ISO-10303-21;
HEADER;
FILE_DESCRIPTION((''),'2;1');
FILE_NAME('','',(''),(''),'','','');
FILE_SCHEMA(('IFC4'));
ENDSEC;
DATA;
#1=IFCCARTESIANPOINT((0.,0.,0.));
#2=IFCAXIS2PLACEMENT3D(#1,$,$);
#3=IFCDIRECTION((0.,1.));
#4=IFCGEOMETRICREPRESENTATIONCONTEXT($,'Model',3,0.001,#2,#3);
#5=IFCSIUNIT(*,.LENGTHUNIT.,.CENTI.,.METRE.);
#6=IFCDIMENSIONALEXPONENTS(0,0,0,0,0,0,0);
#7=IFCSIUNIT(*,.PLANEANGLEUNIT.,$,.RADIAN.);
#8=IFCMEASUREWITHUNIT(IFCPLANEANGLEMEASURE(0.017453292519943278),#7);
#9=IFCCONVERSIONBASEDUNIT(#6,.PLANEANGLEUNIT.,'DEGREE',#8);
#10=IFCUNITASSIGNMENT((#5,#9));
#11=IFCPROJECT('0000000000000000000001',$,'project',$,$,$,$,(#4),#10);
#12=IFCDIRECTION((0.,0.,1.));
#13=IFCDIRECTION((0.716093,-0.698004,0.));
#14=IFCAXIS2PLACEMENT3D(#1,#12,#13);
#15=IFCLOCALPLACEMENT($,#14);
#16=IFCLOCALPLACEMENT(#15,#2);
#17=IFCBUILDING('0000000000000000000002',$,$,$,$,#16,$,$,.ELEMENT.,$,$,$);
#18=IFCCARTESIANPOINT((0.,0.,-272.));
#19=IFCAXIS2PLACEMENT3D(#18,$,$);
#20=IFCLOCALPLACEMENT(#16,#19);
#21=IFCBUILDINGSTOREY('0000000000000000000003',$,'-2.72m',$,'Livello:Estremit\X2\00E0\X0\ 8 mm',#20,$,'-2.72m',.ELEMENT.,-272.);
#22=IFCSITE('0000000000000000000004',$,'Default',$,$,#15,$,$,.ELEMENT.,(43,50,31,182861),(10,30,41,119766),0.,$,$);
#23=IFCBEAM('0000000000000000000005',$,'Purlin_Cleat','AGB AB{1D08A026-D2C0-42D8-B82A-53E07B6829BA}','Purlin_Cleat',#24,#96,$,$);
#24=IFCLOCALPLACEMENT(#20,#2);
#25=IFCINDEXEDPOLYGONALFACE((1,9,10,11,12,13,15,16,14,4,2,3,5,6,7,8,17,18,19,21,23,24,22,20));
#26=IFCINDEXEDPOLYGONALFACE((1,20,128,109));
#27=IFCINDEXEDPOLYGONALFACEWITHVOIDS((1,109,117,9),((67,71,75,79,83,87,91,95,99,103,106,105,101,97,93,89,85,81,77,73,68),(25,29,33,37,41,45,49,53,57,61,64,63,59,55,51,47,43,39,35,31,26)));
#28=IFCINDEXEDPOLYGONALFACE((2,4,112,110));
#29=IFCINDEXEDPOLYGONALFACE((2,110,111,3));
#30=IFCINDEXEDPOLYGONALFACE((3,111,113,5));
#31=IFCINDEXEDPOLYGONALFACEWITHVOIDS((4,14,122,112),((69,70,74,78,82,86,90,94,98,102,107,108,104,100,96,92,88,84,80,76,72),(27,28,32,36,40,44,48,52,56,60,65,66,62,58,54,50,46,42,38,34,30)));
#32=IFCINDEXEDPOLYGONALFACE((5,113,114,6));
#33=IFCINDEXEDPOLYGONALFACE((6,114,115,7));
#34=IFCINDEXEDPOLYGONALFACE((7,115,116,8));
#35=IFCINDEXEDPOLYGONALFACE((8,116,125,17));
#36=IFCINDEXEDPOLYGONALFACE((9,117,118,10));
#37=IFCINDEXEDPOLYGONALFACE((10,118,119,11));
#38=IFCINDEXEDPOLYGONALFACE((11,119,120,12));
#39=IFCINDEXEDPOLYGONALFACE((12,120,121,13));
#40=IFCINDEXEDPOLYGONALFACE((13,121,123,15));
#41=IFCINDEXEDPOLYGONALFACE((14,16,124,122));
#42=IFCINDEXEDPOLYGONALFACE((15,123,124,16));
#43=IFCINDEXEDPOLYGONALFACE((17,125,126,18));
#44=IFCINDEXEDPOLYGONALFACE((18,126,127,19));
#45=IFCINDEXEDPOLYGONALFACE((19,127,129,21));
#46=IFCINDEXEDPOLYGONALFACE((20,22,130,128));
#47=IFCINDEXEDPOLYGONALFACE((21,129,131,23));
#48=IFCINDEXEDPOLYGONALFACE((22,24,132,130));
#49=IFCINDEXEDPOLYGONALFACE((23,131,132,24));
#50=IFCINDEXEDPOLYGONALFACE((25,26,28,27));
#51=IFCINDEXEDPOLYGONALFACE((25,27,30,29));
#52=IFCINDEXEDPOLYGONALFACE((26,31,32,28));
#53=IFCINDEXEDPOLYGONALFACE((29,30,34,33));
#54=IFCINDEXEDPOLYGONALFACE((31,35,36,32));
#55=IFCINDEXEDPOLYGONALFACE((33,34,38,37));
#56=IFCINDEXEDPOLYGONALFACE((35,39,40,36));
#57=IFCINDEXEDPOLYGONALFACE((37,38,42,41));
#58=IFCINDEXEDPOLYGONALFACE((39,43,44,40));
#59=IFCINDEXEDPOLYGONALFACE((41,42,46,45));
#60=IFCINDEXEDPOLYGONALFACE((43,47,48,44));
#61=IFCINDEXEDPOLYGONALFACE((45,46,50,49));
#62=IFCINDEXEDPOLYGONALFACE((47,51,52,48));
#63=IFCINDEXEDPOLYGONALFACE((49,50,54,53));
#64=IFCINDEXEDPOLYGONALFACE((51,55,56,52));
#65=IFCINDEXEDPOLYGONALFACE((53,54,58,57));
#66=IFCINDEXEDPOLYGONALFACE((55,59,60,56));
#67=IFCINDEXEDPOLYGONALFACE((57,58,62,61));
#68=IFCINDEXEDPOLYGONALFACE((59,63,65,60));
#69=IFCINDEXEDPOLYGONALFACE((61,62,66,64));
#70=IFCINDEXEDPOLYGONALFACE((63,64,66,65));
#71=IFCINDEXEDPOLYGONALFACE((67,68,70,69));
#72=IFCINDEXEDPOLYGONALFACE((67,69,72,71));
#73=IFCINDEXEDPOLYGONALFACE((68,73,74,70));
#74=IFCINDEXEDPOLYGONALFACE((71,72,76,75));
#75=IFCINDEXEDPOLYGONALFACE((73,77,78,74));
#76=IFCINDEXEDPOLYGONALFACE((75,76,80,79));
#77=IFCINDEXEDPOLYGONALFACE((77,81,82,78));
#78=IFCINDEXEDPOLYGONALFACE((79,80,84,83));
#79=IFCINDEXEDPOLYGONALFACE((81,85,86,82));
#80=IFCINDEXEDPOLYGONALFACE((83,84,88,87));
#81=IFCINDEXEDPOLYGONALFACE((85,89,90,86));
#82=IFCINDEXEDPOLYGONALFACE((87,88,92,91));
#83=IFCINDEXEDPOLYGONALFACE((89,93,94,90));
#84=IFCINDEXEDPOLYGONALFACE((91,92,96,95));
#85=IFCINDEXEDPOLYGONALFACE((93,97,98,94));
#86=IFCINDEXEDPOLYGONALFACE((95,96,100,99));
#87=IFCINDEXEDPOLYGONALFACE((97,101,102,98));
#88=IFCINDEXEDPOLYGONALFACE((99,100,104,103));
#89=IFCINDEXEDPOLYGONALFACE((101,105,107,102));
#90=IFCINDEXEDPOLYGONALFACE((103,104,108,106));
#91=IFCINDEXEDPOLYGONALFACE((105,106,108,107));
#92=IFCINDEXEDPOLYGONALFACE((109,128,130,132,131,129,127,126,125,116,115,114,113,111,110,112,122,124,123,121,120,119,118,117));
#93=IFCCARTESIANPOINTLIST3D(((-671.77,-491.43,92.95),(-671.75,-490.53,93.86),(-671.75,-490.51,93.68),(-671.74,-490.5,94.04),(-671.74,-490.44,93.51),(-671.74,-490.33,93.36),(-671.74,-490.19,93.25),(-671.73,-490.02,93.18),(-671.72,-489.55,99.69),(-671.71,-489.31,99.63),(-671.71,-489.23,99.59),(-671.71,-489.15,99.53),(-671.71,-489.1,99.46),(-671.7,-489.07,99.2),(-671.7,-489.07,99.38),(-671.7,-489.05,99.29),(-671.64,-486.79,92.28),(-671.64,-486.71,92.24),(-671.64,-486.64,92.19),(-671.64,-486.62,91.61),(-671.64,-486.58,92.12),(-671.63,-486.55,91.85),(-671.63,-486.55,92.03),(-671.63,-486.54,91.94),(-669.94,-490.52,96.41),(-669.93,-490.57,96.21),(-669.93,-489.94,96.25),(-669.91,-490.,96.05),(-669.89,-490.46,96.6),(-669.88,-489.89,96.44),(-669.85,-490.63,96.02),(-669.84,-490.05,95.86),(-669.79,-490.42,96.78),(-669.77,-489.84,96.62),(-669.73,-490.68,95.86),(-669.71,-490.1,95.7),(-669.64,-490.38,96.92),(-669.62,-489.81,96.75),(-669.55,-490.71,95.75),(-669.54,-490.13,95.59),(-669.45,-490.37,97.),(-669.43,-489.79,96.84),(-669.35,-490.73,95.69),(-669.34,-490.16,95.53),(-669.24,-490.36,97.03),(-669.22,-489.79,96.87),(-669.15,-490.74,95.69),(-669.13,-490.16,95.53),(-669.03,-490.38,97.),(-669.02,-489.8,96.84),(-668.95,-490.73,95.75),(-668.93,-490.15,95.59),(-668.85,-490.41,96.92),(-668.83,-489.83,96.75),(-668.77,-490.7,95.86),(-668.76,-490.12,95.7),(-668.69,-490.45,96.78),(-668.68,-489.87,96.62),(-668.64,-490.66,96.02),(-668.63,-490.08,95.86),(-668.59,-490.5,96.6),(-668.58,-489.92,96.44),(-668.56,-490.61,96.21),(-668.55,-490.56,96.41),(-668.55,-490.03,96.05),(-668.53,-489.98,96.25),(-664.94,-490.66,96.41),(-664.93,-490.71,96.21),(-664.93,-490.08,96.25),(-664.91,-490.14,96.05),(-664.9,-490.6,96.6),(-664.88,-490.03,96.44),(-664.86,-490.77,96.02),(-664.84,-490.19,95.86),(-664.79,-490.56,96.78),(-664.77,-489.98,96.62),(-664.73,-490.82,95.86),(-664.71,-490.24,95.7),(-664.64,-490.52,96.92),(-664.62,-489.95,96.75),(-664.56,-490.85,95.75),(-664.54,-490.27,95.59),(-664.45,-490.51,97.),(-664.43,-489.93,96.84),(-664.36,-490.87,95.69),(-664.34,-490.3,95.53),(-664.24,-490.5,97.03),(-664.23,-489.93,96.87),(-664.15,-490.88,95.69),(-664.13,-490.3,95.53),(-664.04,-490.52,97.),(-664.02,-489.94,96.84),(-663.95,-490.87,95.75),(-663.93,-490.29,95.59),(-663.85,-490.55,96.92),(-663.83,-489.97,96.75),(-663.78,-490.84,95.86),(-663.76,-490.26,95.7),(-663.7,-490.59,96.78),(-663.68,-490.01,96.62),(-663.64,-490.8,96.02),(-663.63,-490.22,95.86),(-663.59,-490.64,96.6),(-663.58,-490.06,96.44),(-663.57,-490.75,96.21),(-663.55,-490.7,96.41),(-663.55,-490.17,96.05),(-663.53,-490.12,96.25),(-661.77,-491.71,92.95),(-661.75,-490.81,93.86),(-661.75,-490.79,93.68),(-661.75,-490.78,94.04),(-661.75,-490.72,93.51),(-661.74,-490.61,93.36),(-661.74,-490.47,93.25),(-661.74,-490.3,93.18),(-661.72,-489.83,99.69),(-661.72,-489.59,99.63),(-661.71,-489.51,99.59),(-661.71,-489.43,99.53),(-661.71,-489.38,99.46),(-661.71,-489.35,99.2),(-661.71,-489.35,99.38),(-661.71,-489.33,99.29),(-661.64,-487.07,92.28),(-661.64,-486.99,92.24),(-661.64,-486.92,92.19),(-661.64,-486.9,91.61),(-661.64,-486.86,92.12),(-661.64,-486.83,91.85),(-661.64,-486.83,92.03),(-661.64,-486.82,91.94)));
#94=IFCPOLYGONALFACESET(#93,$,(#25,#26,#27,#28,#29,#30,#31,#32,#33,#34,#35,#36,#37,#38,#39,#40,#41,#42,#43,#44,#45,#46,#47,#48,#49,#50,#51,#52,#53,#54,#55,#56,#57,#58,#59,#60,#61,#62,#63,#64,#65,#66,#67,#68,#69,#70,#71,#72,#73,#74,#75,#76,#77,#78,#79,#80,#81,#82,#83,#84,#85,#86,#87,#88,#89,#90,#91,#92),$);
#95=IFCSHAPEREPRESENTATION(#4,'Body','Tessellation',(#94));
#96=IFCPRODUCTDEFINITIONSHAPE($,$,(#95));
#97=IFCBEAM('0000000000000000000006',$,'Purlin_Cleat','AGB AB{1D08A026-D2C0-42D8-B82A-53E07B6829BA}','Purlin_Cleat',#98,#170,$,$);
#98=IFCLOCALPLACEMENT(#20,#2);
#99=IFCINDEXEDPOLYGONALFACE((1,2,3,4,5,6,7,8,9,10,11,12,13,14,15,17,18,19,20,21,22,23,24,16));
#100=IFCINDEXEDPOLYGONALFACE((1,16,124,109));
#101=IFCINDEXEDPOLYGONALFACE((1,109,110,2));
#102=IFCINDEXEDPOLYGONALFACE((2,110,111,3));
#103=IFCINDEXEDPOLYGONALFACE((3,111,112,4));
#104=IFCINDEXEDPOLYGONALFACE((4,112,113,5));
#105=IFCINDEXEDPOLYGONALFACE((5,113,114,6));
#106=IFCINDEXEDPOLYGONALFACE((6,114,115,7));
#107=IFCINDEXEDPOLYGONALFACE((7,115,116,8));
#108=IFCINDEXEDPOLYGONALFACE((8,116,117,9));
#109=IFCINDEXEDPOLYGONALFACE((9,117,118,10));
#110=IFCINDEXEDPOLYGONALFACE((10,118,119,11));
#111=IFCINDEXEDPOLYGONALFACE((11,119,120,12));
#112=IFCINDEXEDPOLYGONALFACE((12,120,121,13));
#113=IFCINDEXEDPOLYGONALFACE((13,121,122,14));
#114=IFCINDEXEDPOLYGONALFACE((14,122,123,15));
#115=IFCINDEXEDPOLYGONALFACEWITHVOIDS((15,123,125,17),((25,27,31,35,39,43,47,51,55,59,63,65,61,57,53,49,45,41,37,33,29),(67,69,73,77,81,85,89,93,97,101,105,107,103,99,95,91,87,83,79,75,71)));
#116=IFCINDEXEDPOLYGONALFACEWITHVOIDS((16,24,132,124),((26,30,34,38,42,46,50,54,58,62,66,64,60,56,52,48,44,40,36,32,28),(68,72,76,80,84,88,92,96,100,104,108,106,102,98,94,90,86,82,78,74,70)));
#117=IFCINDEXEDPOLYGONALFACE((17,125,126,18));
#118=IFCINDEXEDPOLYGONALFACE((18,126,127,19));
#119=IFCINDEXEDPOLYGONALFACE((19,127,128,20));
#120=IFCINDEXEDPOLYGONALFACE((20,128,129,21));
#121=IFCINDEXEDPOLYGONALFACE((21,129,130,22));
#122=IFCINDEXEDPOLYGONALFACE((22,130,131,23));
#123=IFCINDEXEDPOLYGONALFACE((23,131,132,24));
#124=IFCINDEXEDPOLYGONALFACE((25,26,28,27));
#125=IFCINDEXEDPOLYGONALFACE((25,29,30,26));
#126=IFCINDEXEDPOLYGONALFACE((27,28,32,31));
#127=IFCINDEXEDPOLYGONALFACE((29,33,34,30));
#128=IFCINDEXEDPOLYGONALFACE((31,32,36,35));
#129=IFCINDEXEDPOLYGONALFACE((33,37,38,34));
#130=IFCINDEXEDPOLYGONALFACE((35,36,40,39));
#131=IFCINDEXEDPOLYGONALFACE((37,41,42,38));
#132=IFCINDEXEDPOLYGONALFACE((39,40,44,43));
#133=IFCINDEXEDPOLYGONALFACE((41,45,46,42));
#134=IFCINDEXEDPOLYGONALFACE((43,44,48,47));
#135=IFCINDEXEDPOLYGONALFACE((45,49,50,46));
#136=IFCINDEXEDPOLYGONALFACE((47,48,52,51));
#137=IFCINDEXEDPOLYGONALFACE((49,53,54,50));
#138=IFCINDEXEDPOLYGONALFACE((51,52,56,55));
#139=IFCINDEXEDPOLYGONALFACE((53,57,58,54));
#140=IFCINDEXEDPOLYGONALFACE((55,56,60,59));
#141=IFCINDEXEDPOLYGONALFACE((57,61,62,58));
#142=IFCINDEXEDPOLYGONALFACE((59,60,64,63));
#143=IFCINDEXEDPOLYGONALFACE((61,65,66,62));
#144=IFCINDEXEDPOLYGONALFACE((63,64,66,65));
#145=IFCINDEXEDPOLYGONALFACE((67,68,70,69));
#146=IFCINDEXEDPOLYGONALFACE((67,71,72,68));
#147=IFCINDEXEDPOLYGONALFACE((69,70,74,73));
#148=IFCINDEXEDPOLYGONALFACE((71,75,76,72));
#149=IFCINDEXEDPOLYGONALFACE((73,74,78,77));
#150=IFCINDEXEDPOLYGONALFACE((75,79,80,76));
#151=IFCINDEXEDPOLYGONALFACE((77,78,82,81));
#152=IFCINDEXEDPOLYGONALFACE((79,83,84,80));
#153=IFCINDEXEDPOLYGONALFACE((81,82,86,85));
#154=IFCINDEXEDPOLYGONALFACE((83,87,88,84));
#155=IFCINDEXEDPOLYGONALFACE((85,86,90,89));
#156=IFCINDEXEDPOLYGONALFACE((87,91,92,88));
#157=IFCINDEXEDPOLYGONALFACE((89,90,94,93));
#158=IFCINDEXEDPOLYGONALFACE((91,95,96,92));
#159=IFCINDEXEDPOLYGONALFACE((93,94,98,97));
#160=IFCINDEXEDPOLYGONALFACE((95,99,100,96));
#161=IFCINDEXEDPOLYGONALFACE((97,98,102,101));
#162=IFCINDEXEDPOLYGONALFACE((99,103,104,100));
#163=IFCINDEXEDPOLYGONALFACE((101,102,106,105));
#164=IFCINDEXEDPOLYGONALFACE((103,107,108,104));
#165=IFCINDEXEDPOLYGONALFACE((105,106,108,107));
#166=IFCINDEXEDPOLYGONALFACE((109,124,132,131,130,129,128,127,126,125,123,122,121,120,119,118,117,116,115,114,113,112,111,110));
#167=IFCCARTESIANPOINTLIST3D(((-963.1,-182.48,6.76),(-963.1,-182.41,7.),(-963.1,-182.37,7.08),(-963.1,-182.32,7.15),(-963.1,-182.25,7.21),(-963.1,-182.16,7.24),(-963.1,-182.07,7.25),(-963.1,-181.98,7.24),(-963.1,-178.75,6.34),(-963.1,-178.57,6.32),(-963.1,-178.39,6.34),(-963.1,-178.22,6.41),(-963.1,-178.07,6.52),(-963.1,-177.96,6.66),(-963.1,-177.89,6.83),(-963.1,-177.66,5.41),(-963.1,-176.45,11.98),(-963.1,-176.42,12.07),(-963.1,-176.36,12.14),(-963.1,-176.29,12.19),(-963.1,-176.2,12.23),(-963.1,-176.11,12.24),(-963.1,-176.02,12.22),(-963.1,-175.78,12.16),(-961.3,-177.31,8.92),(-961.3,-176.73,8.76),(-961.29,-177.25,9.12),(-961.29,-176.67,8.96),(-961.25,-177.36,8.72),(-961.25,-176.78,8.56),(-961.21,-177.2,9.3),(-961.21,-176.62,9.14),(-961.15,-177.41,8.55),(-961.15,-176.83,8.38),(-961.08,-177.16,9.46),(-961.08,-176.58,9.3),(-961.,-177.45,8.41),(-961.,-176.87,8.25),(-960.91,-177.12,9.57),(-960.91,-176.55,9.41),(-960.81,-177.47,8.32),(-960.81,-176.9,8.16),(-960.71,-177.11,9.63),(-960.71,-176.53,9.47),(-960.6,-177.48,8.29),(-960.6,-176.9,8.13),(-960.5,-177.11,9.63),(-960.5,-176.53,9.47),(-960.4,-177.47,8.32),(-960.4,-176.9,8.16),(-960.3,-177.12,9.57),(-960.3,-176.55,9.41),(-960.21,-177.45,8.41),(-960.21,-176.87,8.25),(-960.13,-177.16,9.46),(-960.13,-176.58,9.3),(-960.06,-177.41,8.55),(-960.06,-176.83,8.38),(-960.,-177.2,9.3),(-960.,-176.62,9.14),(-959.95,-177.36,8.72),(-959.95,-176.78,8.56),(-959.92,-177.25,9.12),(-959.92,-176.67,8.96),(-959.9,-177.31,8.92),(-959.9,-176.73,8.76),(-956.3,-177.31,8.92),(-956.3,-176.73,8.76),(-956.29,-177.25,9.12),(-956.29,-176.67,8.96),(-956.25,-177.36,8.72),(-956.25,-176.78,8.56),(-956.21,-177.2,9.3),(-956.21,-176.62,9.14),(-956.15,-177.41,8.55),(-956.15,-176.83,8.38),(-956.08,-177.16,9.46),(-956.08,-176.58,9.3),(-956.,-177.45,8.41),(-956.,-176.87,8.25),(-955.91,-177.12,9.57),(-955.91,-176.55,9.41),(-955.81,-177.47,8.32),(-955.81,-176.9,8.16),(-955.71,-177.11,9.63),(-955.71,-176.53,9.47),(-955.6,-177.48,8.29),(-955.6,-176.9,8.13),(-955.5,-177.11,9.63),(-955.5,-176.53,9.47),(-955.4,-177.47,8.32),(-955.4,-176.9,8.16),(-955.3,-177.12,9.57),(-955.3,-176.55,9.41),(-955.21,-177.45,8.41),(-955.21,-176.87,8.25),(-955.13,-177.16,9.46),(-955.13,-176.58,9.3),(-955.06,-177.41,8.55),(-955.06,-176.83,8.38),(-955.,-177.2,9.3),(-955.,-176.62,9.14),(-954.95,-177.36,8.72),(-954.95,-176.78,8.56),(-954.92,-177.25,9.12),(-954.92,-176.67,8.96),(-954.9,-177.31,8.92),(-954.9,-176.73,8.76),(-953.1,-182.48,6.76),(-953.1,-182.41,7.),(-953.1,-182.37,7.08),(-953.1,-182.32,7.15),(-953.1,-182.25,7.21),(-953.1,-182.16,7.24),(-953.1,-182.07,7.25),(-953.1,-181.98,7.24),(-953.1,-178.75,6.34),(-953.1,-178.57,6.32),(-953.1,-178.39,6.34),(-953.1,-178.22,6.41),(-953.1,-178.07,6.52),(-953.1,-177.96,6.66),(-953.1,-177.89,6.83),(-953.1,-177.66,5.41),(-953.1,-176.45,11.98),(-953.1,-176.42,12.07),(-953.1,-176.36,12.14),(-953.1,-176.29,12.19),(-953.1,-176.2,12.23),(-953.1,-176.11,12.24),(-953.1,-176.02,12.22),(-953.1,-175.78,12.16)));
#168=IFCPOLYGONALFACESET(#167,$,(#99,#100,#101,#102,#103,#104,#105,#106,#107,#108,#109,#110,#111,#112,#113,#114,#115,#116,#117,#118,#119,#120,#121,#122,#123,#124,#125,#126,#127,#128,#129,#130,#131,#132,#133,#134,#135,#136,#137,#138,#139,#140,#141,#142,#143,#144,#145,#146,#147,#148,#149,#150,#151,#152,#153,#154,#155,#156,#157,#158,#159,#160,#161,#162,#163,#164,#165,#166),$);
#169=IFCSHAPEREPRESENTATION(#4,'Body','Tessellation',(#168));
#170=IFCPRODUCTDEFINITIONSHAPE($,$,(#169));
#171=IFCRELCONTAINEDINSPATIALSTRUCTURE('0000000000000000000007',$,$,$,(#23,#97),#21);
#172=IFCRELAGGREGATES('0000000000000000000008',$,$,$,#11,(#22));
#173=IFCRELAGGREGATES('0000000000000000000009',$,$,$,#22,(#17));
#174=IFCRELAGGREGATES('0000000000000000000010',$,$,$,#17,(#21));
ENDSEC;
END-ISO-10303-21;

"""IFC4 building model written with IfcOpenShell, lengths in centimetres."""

from ifc_helpers import new_model, entity, si_unit, converted_unit, direction, frame, frame_2d, origin, place, context, project, spatial, circle, l_section, extrude, element, save


model = new_model("IFC4")

# Units and contexts
model_context = context("Model", 3, precision=0.001, world=origin(), true_north=direction((0.0, 1.0)))
ifc_project = project(units=[si_unit("LENGTHUNIT", "METRE", prefix="CENTI"), converted_unit("PLANEANGLEUNIT", "DEGREE", entity("IfcPlaneAngleMeasure", 0.017453292519943278), si_unit("PLANEANGLEUNIT", "RADIAN"), dimensions=[0, 0, 0, 0, 0, 0, 0])], contexts=[model_context])

# Site, building, storey
site_placement = place(None, frame((0.0, 0.0, 0.0), z_axis=(0.0, 0.0, 1.0), x_axis=(0.716093, -0.698004, 0.0)))
site = spatial("IfcSite", under=ifc_project, at=site_placement, Name="Default", CompositionType="ELEMENT", RefLatitude=(43, 50, 31, 182861), RefLongitude=(10, 30, 41, 119766), RefElevation=0.0)
building_placement = place(site_placement, origin())
building = spatial("IfcBuilding", under=site, at=building_placement, CompositionType="ELEMENT")
storey_placement = place(building_placement, frame((0.0, 0.0, -272.0)))
storey = spatial("IfcBuildingStorey", under=building, at=storey_placement, Name="-2.72m", ObjectType="Livello:Estremità 8 mm", LongName="-2.72m", CompositionType="ELEMENT", Elevation=-272.0)

# Beams, openings
beam_1_placement = place(storey_placement, frame((-661.72, -489.92, 94.79), z_axis=(-0.999608, 0.02798, 0.0), x_axis=(0.007515, 0.268478, 0.963256)))
beam_1 = element("IfcBeam", 1, at=beam_1_placement, inside=storey, Name="Purlin_Cleat", Description="AGB AB{1D08A026-D2C0-42D8-B82A-53E07B6829BA}", ObjectType="Purlin_Cleat", context=model_context, shape_type="SweptSolid", body=[
    extrude(l_section(Depth=5.0, Width=7.0, Thickness=0.6, FilletRadius=0.7, EdgeRadius=0.35, at=frame_2d((1.25, 1.27))), origin(), (0.0, 0.0, 1.0), 10.0),
])
opening_1_placement = place(beam_1_placement, frame((1.29, -1.3, 6.8), z_axis=(0.0, -1.0, 0.0), x_axis=(1.0, 0.0, 0.0)))
element("IfcOpeningElement", 2, at=opening_1_placement, cuts=beam_1, ObjectType="Opening", context=model_context, shape_type="SweptSolid", body=[
    extrude(circle(Radius=0.7, at=frame_2d((0.0, 0.7), x_axis=(1.0, 0.0))), origin(), (0.0, 0.0, -1.0), 0.7),
])
opening_2_placement = place(beam_1_placement, frame((1.29, -1.3, 1.8), z_axis=(0.0, -1.0, 0.0), x_axis=(1.0, 0.0, 0.0)))
element("IfcOpeningElement", 3, at=opening_2_placement, cuts=beam_1, ObjectType="Opening", context=model_context, shape_type="SweptSolid", body=[
    extrude(circle(Radius=0.7, at=frame_2d((0.0, 0.7), x_axis=(1.0, 0.0))), origin(), (0.0, 0.0, -1.0), 0.7),
])
beam_2_placement = place(storey_placement, frame((-953.1, -178.24, 7.91), z_axis=(1.0, 0.0, 0.0), x_axis=(0.0, 0.268584, 0.963256)))
beam_2 = element("IfcBeam", 4, at=beam_2_placement, inside=storey, Name="Purlin_Cleat", Description="AGB AB{1D08A026-D2C0-42D8-B82A-53E07B6829BA}", ObjectType="Purlin_Cleat", context=model_context, shape_type="SweptSolid", body=[
    extrude(l_section(Depth=5.0, Width=7.0, Thickness=0.6, FilletRadius=0.7, EdgeRadius=0.35, at=frame_2d((1.25, 1.27))), origin(), (0.0, 0.0, -1.0), 10.0),
])
opening_3_placement = place(beam_2_placement, frame((1.27, -0.6, -3.2), z_axis=(0.0, 1.0, 0.0), x_axis=(-1.0, 0.0, 0.0)))
element("IfcOpeningElement", 5, at=opening_3_placement, cuts=beam_2, ObjectType="Opening", context=model_context, shape_type="SweptSolid", body=[
    extrude(circle(Radius=0.7, at=frame_2d((0.0, 0.7), x_axis=(1.0, 0.0))), origin(), (0.0, 0.0, -1.0), 0.7),
])
opening_4_placement = place(beam_2_placement, frame((1.27, -0.6, -8.2), z_axis=(0.0, 1.0, 0.0), x_axis=(-1.0, 0.0, 0.0)))
element("IfcOpeningElement", 6, at=opening_4_placement, cuts=beam_2, ObjectType="Opening", context=model_context, shape_type="SweptSolid", body=[
    extrude(circle(Radius=0.7, at=frame_2d((0.0, 0.7), x_axis=(1.0, 0.0))), origin(), (0.0, 0.0, -1.0), 0.7),
])

save(model, "model.ifc")
